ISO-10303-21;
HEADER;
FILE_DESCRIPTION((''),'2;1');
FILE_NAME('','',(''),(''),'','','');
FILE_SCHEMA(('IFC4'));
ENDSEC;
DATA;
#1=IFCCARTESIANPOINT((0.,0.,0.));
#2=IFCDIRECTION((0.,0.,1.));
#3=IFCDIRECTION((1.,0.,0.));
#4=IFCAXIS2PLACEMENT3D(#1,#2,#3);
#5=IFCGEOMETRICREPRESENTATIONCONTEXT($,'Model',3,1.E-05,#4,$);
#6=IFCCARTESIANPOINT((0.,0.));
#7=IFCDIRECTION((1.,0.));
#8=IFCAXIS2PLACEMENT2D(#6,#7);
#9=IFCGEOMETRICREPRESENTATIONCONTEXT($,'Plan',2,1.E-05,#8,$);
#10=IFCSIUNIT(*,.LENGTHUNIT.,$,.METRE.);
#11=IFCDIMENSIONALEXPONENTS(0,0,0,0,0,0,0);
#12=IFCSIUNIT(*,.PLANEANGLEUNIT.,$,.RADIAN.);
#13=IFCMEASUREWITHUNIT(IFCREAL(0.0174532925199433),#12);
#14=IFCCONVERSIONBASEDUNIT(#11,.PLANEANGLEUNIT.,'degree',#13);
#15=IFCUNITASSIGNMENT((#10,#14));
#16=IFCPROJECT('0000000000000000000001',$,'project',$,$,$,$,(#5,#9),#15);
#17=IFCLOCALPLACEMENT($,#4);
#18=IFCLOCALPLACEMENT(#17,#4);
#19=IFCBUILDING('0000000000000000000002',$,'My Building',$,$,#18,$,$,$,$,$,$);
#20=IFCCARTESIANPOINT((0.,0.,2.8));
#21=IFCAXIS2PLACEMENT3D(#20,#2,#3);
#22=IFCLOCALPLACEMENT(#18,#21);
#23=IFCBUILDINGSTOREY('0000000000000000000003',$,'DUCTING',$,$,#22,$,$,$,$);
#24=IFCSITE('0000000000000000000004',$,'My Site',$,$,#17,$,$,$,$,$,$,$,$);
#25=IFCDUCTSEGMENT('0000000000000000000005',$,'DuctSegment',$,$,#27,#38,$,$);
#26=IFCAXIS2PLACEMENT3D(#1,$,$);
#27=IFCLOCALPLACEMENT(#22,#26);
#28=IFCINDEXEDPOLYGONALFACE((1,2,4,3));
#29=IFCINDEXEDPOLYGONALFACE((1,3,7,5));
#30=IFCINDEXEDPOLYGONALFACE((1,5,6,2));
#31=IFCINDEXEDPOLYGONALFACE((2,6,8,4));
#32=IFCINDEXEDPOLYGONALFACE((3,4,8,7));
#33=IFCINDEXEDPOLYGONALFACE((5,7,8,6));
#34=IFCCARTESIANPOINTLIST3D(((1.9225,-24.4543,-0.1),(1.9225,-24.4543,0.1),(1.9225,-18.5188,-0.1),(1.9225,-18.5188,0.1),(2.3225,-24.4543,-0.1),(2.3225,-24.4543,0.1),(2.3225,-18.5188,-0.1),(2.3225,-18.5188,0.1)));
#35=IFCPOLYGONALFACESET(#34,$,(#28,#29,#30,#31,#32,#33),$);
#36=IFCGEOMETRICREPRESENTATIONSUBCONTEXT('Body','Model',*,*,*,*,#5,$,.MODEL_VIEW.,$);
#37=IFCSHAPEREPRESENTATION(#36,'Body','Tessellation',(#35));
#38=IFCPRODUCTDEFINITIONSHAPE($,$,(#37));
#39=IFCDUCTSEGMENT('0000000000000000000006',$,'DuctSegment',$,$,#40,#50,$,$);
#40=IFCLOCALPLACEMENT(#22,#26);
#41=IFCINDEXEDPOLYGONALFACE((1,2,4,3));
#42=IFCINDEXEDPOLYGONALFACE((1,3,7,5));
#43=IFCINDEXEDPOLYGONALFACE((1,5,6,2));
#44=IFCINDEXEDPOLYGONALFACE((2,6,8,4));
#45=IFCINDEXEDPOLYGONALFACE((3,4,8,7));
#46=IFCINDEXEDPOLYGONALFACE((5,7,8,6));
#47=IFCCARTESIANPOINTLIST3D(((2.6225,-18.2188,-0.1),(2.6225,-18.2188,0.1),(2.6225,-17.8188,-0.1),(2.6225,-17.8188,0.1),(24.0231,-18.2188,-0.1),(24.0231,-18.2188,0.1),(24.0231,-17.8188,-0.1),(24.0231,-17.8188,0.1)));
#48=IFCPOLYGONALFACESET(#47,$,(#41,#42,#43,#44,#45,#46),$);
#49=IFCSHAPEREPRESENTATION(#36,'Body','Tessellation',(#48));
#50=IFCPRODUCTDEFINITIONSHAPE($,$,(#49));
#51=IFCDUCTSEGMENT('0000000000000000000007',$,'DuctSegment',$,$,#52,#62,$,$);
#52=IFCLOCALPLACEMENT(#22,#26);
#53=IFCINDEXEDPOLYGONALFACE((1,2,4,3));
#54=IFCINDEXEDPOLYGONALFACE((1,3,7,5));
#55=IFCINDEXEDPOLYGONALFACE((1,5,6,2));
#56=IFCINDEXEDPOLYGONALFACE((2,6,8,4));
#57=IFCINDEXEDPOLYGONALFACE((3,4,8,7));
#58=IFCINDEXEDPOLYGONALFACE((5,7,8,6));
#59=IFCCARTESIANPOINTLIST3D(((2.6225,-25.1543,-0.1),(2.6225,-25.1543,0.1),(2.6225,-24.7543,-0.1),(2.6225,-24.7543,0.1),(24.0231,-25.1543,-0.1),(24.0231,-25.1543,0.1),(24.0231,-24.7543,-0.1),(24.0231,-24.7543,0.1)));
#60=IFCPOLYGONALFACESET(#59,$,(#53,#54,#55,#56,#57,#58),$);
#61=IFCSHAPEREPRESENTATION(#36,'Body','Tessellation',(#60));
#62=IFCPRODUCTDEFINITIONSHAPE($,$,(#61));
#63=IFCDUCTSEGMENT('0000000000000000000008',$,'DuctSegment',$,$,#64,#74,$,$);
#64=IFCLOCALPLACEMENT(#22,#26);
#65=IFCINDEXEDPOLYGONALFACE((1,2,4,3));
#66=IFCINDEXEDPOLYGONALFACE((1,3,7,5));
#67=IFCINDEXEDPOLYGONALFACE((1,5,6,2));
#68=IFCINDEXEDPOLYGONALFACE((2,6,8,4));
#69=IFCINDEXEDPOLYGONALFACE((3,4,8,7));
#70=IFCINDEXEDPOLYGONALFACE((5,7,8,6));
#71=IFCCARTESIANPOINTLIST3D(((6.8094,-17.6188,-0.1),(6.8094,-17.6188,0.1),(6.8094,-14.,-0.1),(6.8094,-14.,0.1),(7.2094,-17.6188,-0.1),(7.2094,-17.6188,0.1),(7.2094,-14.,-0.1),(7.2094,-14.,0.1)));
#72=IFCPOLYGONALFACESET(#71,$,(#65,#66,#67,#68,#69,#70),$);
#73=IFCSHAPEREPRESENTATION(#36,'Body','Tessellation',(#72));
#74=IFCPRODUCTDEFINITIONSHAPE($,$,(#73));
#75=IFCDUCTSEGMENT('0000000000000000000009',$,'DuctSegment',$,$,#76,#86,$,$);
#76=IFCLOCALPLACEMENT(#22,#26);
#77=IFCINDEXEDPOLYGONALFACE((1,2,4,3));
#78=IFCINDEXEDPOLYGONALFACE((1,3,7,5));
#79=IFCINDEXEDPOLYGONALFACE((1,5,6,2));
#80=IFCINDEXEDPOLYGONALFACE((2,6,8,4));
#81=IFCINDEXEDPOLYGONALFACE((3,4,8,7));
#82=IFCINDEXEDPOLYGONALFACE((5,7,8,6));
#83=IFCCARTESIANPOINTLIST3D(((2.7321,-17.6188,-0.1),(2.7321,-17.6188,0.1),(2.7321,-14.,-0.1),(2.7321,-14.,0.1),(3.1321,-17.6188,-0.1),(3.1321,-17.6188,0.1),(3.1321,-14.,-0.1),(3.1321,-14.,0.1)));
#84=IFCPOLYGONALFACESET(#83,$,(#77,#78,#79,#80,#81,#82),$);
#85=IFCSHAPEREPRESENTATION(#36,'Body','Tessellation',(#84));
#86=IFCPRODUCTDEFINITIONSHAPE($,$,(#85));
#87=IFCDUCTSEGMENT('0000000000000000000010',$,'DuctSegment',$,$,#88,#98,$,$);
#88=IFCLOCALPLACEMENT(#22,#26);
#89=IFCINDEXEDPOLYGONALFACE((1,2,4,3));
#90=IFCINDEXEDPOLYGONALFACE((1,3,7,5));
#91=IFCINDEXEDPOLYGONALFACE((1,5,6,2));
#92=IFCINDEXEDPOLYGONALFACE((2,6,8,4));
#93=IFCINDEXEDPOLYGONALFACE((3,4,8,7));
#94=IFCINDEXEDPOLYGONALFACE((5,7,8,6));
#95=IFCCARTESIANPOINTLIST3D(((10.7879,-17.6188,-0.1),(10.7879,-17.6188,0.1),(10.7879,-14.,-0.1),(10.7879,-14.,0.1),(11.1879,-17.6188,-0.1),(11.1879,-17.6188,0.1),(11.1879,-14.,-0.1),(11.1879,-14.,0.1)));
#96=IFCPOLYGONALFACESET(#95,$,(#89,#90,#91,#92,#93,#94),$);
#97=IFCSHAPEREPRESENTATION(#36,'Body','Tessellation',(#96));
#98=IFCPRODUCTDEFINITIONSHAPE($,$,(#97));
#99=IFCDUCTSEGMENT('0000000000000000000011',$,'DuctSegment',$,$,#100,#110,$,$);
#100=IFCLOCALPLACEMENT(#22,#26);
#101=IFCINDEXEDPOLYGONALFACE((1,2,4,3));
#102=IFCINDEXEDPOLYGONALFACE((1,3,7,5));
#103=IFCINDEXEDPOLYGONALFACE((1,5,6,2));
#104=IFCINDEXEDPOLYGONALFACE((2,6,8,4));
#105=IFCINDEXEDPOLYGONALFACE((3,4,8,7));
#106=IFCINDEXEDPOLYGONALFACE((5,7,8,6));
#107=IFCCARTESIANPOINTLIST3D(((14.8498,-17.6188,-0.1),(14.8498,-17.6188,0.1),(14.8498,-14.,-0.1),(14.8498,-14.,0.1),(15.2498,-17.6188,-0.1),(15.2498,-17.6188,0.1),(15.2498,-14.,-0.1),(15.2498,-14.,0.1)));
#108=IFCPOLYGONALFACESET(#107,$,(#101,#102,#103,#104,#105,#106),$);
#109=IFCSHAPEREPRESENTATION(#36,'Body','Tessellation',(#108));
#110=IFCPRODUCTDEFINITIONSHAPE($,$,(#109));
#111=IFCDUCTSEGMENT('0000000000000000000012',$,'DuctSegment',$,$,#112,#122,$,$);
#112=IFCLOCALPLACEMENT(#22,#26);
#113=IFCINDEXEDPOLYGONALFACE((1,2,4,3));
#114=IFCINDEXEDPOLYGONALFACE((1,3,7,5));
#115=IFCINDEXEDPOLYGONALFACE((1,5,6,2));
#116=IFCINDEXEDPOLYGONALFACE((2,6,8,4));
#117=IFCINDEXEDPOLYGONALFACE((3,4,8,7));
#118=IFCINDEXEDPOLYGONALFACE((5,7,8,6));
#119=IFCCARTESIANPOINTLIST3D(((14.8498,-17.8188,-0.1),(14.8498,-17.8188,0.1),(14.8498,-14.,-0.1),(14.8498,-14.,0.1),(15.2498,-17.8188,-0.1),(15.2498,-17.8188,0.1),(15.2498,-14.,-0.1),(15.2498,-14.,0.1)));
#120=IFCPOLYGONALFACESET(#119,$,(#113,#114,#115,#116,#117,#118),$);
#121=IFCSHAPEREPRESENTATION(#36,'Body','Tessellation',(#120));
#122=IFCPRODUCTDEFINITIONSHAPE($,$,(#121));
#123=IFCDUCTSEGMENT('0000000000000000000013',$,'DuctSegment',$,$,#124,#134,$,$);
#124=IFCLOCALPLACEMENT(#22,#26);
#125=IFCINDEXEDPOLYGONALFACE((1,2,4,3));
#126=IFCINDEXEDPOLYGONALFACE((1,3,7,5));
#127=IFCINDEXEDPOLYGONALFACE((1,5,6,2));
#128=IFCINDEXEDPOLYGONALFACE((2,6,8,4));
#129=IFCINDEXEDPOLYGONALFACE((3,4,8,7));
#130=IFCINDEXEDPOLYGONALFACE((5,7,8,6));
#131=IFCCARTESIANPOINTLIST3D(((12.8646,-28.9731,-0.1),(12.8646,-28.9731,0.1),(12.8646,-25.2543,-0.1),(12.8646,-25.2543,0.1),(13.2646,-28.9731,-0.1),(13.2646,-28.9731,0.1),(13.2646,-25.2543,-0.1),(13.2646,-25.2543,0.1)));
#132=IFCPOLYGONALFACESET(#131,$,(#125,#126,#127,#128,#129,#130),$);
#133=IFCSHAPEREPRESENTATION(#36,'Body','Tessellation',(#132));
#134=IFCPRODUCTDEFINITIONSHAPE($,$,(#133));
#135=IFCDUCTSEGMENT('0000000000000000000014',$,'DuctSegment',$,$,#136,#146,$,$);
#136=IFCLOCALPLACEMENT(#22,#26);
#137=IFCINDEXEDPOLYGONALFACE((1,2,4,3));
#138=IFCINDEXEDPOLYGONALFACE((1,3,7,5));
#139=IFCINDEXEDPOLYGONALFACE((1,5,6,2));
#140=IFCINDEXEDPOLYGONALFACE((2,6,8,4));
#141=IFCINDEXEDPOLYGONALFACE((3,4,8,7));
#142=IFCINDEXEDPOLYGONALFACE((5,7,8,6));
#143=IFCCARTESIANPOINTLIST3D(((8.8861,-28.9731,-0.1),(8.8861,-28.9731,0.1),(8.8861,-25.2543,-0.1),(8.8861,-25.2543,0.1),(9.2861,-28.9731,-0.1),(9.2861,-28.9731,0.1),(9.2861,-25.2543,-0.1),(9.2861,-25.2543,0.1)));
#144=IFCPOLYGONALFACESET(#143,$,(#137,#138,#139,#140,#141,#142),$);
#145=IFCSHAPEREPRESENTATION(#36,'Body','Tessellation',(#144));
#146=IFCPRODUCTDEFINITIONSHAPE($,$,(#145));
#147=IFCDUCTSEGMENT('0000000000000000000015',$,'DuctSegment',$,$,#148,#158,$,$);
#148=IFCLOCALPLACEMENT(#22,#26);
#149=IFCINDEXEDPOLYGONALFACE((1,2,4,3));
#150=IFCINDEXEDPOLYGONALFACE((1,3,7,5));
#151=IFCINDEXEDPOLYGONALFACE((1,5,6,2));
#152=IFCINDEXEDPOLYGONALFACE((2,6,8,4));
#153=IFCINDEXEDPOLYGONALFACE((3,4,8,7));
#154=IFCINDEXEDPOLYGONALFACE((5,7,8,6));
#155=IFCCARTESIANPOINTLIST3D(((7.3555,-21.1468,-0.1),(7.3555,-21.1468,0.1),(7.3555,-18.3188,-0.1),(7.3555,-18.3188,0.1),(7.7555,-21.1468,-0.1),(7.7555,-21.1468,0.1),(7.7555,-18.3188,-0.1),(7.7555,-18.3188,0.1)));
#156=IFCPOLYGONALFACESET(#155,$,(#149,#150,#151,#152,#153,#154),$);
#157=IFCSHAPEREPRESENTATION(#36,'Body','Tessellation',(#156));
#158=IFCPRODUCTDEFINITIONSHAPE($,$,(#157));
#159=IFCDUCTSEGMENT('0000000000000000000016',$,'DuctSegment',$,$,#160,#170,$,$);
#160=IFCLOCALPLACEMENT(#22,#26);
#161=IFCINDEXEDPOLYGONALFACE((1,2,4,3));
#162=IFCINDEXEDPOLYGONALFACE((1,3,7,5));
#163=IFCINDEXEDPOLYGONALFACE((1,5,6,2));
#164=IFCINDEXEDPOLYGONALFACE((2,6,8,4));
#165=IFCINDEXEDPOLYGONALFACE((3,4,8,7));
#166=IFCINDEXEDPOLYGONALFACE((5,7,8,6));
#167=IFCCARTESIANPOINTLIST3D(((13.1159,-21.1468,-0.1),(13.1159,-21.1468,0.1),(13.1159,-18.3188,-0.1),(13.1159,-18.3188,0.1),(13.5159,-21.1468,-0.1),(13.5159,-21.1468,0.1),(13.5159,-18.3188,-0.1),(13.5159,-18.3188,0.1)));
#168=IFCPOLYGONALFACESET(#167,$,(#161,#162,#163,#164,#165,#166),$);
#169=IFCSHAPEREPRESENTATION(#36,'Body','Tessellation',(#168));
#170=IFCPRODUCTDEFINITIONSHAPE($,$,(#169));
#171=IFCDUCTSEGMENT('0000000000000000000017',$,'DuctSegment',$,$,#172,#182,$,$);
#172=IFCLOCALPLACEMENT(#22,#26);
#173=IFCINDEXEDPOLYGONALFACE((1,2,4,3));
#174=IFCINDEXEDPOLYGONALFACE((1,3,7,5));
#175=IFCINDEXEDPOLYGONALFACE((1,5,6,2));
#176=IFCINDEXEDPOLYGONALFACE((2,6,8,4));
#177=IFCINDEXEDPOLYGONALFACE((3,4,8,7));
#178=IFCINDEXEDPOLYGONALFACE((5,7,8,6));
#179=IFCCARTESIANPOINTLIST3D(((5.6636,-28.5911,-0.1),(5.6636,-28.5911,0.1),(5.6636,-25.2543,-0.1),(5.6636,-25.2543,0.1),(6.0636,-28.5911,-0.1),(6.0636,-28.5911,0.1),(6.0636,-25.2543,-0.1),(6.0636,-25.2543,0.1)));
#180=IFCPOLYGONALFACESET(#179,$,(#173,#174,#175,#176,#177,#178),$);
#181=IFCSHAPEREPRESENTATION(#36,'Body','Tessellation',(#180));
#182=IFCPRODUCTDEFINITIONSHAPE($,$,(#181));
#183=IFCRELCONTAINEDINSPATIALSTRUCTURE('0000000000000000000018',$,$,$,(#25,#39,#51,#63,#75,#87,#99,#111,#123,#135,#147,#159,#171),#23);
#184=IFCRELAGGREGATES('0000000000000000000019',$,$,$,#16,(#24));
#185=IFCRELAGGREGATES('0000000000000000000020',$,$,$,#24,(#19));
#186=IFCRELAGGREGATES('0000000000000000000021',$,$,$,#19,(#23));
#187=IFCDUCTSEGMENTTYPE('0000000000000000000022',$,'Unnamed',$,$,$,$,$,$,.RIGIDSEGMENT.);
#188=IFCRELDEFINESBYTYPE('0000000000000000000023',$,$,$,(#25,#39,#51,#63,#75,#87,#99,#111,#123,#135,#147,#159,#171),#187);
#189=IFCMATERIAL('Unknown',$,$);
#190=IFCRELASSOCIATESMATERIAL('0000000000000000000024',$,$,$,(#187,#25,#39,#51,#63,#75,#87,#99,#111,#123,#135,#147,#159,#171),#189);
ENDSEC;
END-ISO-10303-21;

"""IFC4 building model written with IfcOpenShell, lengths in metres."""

from ifc_helpers import new_model, entity, si_unit, converted_unit, frame, origin_with_axes, origin_2d_with_axis, place, context, subcontext, project, spatial, rectangle, extrude, material, material_profile, profile_set, profile_usage, type_object, element, save


model = new_model("IFC4")

# Units and contexts
model_context = context("Model", 3, precision=1e-05, world=origin_with_axes())
plan_context = context("Plan", 2, precision=1e-05, world=origin_2d_with_axis())
body_context = subcontext(model_context, "Body", "Model", "MODEL_VIEW")
ifc_project = project(units=[si_unit("LENGTHUNIT", "METRE"), converted_unit("PLANEANGLEUNIT", "degree", entity("IfcReal", 0.0174532925199433), si_unit("PLANEANGLEUNIT", "RADIAN"), dimensions=[0, 0, 0, 0, 0, 0, 0])], contexts=[model_context, plan_context])

# Site, building, storey
site_placement = place(None, origin_with_axes())
site = spatial("IfcSite", under=ifc_project, at=site_placement, Name="My Site")
building_placement = place(site_placement, origin_with_axes())
building = spatial("IfcBuilding", under=site, at=building_placement, Name="My Building")
storey_placement = place(building_placement, frame((0.0, 0.0, 2.8), z_axis=(0.0, 0.0, 1.0), x_axis=(1.0, 0.0, 0.0)))
storey = spatial("IfcBuildingStorey", under=building, at=storey_placement, Name="DUCTING")

# Duct segments
ifc_material = material(Name="Unknown")
ifc_material_profile_1 = material_profile(ifc_material, rectangle(XDim=0.4, YDim=0.2))
ifc_profile_set_1 = profile_set([ifc_material_profile_1])
ifc_profile_usage_1 = profile_usage(ifc_profile_set_1, cardinal=5)
duct_segment_type = type_object("IfcDuctSegmentType", Name="Unnamed", PredefinedType="RIGIDSEGMENT", material=ifc_profile_set_1)
duct_segment_1_placement = place(storey_placement, frame((2.1225, -18.5188, 0.0), z_axis=(0.000006, -1.0, 0.0), x_axis=(1.0, 0.000006, 0.0)))
element("IfcDuctSegment", 1, at=duct_segment_1_placement, inside=storey, type_object=duct_segment_type, material=ifc_profile_usage_1, Name="DuctSegment", context=body_context, shape_type="SweptSolid", body=[
    extrude(rectangle(XDim=0.4, YDim=0.2), origin_with_axes(), (0.0, 0.0, 1.0), 5.9355),
])
ifc_profile_usage_2 = profile_usage(ifc_profile_set_1, cardinal=5)
duct_segment_2_placement = place(storey_placement, frame((2.6225, -18.0188, 0.0), z_axis=(1.0, -0.000001, 0.0), x_axis=(0.000001, 1.0, 0.0)))
element("IfcDuctSegment", 2, at=duct_segment_2_placement, inside=storey, type_object=duct_segment_type, material=ifc_profile_usage_2, Name="DuctSegment", context=body_context, shape_type="SweptSolid", body=[
    extrude(rectangle(XDim=0.4, YDim=0.2), origin_with_axes(), (0.0, 0.0, 1.0), 21.4006),
])
ifc_profile_usage_3 = profile_usage(ifc_profile_set_1, cardinal=5)
duct_segment_3_placement = place(storey_placement, frame((2.6225, -24.9543, 0.0), z_axis=(1.0, -0.000001, 0.0), x_axis=(0.000001, 1.0, 0.0)))
element("IfcDuctSegment", 3, at=duct_segment_3_placement, inside=storey, type_object=duct_segment_type, material=ifc_profile_usage_3, Name="DuctSegment", context=body_context, shape_type="SweptSolid", body=[
    extrude(rectangle(XDim=0.4, YDim=0.2), origin_with_axes(), (0.0, 0.0, 1.0), 21.4006),
])
ifc_profile_usage_4 = profile_usage(ifc_profile_set_1, cardinal=5)
duct_segment_4_placement = place(storey_placement, frame((7.0094, -17.6188, 0.0), z_axis=(0.0, 1.0, 0.0), x_axis=(-1.0, 0.0, 0.0)))
element("IfcDuctSegment", 4, at=duct_segment_4_placement, inside=storey, type_object=duct_segment_type, material=ifc_profile_usage_4, Name="DuctSegment", context=body_context, shape_type="SweptSolid", body=[
    extrude(rectangle(XDim=0.4, YDim=0.2), origin_with_axes(), (0.0, 0.0, 1.0), 3.6188),
])
ifc_profile_usage_5 = profile_usage(ifc_profile_set_1, cardinal=5)
duct_segment_5_placement = place(storey_placement, frame((2.9321, -17.6188, 0.0), z_axis=(0.0, 1.0, 0.0), x_axis=(-1.0, 0.0, 0.0)))
element("IfcDuctSegment", 5, at=duct_segment_5_placement, inside=storey, type_object=duct_segment_type, material=ifc_profile_usage_5, Name="DuctSegment", context=body_context, shape_type="SweptSolid", body=[
    extrude(rectangle(XDim=0.4, YDim=0.2), origin_with_axes(), (0.0, 0.0, 1.0), 3.6188),
])
ifc_profile_usage_6 = profile_usage(ifc_profile_set_1, cardinal=5)
duct_segment_6_placement = place(storey_placement, frame((10.9879, -17.6188, 0.0), z_axis=(0.0, 1.0, 0.0), x_axis=(-1.0, 0.0, 0.0)))
element("IfcDuctSegment", 6, at=duct_segment_6_placement, inside=storey, type_object=duct_segment_type, material=ifc_profile_usage_6, Name="DuctSegment", context=body_context, shape_type="SweptSolid", body=[
    extrude(rectangle(XDim=0.4, YDim=0.2), origin_with_axes(), (0.0, 0.0, 1.0), 3.6188),
])
ifc_profile_usage_7 = profile_usage(ifc_profile_set_1, cardinal=5)
duct_segment_7_placement = place(storey_placement, frame((15.0498, -17.6188, 0.0), z_axis=(0.0, 1.0, 0.0), x_axis=(-1.0, 0.0, 0.0)))
element("IfcDuctSegment", 7, at=duct_segment_7_placement, inside=storey, type_object=duct_segment_type, material=ifc_profile_usage_7, Name="DuctSegment", context=body_context, shape_type="SweptSolid", body=[
    extrude(rectangle(XDim=0.4, YDim=0.2), origin_with_axes(), (0.0, 0.0, 1.0), 3.6188),
])
ifc_profile_usage_8 = profile_usage(ifc_profile_set_1, cardinal=5)
duct_segment_8_placement = place(storey_placement, frame((15.0498, -17.8188, 0.0), z_axis=(0.0, 1.0, 0.0), x_axis=(-1.0, 0.0, 0.0)))
element("IfcDuctSegment", 8, at=duct_segment_8_placement, inside=storey, type_object=duct_segment_type, material=ifc_profile_usage_8, Name="DuctSegment", context=body_context, shape_type="SweptSolid", body=[
    extrude(rectangle(XDim=0.4, YDim=0.2), origin_with_axes(), (0.0, 0.0, 1.0), 3.8188),
])
ifc_profile_usage_9 = profile_usage(ifc_profile_set_1, cardinal=5)
duct_segment_9_placement = place(storey_placement, frame((13.0646, -25.2543, 0.0), z_axis=(0.0, -1.0, 0.0), x_axis=(1.0, 0.0, 0.0)))
element("IfcDuctSegment", 9, at=duct_segment_9_placement, inside=storey, type_object=duct_segment_type, material=ifc_profile_usage_9, Name="DuctSegment", context=body_context, shape_type="SweptSolid", body=[
    extrude(rectangle(XDim=0.4, YDim=0.2), origin_with_axes(), (0.0, 0.0, 1.0), 3.7188),
])
ifc_profile_usage_10 = profile_usage(ifc_profile_set_1, cardinal=5)
duct_segment_10_placement = place(storey_placement, frame((9.0861, -25.2543, 0.0), z_axis=(0.0, -1.0, 0.0), x_axis=(1.0, 0.0, 0.0)))
element("IfcDuctSegment", 10, at=duct_segment_10_placement, inside=storey, type_object=duct_segment_type, material=ifc_profile_usage_10, Name="DuctSegment", context=body_context, shape_type="SweptSolid", body=[
    extrude(rectangle(XDim=0.4, YDim=0.2), origin_with_axes(), (0.0, 0.0, 1.0), 3.7188),
])
ifc_profile_usage_11 = profile_usage(ifc_profile_set_1, cardinal=5)
duct_segment_11_placement = place(storey_placement, frame((7.5555, -18.3188, 0.0), z_axis=(0.0, -1.0, 0.0), x_axis=(1.0, 0.0, 0.0)))
element("IfcDuctSegment", 11, at=duct_segment_11_placement, inside=storey, type_object=duct_segment_type, material=ifc_profile_usage_11, Name="DuctSegment", context=body_context, shape_type="SweptSolid", body=[
    extrude(rectangle(XDim=0.4, YDim=0.2), origin_with_axes(), (0.0, 0.0, 1.0), 2.828),
])
ifc_profile_usage_12 = profile_usage(ifc_profile_set_1, cardinal=5)
duct_segment_12_placement = place(storey_placement, frame((13.3159, -18.3188, 0.0), z_axis=(0.0, -1.0, 0.0), x_axis=(1.0, 0.0, 0.0)))
element("IfcDuctSegment", 12, at=duct_segment_12_placement, inside=storey, type_object=duct_segment_type, material=ifc_profile_usage_12, Name="DuctSegment", context=body_context, shape_type="SweptSolid", body=[
    extrude(rectangle(XDim=0.4, YDim=0.2), origin_with_axes(), (0.0, 0.0, 1.0), 2.828),
])
ifc_profile_usage_13 = profile_usage(ifc_profile_set_1, cardinal=5)
duct_segment_13_placement = place(storey_placement, frame((5.8636, -25.2543, 0.0), z_axis=(0.0, -1.0, 0.0), x_axis=(1.0, 0.0, 0.0)))
element("IfcDuctSegment", 13, at=duct_segment_13_placement, inside=storey, type_object=duct_segment_type, material=ifc_profile_usage_13, Name="DuctSegment", context=body_context, shape_type="SweptSolid", body=[
    extrude(rectangle(XDim=0.4, YDim=0.2), origin_with_axes(), (0.0, 0.0, 1.0), 3.3367),
])

save(model, "model.ifc")
